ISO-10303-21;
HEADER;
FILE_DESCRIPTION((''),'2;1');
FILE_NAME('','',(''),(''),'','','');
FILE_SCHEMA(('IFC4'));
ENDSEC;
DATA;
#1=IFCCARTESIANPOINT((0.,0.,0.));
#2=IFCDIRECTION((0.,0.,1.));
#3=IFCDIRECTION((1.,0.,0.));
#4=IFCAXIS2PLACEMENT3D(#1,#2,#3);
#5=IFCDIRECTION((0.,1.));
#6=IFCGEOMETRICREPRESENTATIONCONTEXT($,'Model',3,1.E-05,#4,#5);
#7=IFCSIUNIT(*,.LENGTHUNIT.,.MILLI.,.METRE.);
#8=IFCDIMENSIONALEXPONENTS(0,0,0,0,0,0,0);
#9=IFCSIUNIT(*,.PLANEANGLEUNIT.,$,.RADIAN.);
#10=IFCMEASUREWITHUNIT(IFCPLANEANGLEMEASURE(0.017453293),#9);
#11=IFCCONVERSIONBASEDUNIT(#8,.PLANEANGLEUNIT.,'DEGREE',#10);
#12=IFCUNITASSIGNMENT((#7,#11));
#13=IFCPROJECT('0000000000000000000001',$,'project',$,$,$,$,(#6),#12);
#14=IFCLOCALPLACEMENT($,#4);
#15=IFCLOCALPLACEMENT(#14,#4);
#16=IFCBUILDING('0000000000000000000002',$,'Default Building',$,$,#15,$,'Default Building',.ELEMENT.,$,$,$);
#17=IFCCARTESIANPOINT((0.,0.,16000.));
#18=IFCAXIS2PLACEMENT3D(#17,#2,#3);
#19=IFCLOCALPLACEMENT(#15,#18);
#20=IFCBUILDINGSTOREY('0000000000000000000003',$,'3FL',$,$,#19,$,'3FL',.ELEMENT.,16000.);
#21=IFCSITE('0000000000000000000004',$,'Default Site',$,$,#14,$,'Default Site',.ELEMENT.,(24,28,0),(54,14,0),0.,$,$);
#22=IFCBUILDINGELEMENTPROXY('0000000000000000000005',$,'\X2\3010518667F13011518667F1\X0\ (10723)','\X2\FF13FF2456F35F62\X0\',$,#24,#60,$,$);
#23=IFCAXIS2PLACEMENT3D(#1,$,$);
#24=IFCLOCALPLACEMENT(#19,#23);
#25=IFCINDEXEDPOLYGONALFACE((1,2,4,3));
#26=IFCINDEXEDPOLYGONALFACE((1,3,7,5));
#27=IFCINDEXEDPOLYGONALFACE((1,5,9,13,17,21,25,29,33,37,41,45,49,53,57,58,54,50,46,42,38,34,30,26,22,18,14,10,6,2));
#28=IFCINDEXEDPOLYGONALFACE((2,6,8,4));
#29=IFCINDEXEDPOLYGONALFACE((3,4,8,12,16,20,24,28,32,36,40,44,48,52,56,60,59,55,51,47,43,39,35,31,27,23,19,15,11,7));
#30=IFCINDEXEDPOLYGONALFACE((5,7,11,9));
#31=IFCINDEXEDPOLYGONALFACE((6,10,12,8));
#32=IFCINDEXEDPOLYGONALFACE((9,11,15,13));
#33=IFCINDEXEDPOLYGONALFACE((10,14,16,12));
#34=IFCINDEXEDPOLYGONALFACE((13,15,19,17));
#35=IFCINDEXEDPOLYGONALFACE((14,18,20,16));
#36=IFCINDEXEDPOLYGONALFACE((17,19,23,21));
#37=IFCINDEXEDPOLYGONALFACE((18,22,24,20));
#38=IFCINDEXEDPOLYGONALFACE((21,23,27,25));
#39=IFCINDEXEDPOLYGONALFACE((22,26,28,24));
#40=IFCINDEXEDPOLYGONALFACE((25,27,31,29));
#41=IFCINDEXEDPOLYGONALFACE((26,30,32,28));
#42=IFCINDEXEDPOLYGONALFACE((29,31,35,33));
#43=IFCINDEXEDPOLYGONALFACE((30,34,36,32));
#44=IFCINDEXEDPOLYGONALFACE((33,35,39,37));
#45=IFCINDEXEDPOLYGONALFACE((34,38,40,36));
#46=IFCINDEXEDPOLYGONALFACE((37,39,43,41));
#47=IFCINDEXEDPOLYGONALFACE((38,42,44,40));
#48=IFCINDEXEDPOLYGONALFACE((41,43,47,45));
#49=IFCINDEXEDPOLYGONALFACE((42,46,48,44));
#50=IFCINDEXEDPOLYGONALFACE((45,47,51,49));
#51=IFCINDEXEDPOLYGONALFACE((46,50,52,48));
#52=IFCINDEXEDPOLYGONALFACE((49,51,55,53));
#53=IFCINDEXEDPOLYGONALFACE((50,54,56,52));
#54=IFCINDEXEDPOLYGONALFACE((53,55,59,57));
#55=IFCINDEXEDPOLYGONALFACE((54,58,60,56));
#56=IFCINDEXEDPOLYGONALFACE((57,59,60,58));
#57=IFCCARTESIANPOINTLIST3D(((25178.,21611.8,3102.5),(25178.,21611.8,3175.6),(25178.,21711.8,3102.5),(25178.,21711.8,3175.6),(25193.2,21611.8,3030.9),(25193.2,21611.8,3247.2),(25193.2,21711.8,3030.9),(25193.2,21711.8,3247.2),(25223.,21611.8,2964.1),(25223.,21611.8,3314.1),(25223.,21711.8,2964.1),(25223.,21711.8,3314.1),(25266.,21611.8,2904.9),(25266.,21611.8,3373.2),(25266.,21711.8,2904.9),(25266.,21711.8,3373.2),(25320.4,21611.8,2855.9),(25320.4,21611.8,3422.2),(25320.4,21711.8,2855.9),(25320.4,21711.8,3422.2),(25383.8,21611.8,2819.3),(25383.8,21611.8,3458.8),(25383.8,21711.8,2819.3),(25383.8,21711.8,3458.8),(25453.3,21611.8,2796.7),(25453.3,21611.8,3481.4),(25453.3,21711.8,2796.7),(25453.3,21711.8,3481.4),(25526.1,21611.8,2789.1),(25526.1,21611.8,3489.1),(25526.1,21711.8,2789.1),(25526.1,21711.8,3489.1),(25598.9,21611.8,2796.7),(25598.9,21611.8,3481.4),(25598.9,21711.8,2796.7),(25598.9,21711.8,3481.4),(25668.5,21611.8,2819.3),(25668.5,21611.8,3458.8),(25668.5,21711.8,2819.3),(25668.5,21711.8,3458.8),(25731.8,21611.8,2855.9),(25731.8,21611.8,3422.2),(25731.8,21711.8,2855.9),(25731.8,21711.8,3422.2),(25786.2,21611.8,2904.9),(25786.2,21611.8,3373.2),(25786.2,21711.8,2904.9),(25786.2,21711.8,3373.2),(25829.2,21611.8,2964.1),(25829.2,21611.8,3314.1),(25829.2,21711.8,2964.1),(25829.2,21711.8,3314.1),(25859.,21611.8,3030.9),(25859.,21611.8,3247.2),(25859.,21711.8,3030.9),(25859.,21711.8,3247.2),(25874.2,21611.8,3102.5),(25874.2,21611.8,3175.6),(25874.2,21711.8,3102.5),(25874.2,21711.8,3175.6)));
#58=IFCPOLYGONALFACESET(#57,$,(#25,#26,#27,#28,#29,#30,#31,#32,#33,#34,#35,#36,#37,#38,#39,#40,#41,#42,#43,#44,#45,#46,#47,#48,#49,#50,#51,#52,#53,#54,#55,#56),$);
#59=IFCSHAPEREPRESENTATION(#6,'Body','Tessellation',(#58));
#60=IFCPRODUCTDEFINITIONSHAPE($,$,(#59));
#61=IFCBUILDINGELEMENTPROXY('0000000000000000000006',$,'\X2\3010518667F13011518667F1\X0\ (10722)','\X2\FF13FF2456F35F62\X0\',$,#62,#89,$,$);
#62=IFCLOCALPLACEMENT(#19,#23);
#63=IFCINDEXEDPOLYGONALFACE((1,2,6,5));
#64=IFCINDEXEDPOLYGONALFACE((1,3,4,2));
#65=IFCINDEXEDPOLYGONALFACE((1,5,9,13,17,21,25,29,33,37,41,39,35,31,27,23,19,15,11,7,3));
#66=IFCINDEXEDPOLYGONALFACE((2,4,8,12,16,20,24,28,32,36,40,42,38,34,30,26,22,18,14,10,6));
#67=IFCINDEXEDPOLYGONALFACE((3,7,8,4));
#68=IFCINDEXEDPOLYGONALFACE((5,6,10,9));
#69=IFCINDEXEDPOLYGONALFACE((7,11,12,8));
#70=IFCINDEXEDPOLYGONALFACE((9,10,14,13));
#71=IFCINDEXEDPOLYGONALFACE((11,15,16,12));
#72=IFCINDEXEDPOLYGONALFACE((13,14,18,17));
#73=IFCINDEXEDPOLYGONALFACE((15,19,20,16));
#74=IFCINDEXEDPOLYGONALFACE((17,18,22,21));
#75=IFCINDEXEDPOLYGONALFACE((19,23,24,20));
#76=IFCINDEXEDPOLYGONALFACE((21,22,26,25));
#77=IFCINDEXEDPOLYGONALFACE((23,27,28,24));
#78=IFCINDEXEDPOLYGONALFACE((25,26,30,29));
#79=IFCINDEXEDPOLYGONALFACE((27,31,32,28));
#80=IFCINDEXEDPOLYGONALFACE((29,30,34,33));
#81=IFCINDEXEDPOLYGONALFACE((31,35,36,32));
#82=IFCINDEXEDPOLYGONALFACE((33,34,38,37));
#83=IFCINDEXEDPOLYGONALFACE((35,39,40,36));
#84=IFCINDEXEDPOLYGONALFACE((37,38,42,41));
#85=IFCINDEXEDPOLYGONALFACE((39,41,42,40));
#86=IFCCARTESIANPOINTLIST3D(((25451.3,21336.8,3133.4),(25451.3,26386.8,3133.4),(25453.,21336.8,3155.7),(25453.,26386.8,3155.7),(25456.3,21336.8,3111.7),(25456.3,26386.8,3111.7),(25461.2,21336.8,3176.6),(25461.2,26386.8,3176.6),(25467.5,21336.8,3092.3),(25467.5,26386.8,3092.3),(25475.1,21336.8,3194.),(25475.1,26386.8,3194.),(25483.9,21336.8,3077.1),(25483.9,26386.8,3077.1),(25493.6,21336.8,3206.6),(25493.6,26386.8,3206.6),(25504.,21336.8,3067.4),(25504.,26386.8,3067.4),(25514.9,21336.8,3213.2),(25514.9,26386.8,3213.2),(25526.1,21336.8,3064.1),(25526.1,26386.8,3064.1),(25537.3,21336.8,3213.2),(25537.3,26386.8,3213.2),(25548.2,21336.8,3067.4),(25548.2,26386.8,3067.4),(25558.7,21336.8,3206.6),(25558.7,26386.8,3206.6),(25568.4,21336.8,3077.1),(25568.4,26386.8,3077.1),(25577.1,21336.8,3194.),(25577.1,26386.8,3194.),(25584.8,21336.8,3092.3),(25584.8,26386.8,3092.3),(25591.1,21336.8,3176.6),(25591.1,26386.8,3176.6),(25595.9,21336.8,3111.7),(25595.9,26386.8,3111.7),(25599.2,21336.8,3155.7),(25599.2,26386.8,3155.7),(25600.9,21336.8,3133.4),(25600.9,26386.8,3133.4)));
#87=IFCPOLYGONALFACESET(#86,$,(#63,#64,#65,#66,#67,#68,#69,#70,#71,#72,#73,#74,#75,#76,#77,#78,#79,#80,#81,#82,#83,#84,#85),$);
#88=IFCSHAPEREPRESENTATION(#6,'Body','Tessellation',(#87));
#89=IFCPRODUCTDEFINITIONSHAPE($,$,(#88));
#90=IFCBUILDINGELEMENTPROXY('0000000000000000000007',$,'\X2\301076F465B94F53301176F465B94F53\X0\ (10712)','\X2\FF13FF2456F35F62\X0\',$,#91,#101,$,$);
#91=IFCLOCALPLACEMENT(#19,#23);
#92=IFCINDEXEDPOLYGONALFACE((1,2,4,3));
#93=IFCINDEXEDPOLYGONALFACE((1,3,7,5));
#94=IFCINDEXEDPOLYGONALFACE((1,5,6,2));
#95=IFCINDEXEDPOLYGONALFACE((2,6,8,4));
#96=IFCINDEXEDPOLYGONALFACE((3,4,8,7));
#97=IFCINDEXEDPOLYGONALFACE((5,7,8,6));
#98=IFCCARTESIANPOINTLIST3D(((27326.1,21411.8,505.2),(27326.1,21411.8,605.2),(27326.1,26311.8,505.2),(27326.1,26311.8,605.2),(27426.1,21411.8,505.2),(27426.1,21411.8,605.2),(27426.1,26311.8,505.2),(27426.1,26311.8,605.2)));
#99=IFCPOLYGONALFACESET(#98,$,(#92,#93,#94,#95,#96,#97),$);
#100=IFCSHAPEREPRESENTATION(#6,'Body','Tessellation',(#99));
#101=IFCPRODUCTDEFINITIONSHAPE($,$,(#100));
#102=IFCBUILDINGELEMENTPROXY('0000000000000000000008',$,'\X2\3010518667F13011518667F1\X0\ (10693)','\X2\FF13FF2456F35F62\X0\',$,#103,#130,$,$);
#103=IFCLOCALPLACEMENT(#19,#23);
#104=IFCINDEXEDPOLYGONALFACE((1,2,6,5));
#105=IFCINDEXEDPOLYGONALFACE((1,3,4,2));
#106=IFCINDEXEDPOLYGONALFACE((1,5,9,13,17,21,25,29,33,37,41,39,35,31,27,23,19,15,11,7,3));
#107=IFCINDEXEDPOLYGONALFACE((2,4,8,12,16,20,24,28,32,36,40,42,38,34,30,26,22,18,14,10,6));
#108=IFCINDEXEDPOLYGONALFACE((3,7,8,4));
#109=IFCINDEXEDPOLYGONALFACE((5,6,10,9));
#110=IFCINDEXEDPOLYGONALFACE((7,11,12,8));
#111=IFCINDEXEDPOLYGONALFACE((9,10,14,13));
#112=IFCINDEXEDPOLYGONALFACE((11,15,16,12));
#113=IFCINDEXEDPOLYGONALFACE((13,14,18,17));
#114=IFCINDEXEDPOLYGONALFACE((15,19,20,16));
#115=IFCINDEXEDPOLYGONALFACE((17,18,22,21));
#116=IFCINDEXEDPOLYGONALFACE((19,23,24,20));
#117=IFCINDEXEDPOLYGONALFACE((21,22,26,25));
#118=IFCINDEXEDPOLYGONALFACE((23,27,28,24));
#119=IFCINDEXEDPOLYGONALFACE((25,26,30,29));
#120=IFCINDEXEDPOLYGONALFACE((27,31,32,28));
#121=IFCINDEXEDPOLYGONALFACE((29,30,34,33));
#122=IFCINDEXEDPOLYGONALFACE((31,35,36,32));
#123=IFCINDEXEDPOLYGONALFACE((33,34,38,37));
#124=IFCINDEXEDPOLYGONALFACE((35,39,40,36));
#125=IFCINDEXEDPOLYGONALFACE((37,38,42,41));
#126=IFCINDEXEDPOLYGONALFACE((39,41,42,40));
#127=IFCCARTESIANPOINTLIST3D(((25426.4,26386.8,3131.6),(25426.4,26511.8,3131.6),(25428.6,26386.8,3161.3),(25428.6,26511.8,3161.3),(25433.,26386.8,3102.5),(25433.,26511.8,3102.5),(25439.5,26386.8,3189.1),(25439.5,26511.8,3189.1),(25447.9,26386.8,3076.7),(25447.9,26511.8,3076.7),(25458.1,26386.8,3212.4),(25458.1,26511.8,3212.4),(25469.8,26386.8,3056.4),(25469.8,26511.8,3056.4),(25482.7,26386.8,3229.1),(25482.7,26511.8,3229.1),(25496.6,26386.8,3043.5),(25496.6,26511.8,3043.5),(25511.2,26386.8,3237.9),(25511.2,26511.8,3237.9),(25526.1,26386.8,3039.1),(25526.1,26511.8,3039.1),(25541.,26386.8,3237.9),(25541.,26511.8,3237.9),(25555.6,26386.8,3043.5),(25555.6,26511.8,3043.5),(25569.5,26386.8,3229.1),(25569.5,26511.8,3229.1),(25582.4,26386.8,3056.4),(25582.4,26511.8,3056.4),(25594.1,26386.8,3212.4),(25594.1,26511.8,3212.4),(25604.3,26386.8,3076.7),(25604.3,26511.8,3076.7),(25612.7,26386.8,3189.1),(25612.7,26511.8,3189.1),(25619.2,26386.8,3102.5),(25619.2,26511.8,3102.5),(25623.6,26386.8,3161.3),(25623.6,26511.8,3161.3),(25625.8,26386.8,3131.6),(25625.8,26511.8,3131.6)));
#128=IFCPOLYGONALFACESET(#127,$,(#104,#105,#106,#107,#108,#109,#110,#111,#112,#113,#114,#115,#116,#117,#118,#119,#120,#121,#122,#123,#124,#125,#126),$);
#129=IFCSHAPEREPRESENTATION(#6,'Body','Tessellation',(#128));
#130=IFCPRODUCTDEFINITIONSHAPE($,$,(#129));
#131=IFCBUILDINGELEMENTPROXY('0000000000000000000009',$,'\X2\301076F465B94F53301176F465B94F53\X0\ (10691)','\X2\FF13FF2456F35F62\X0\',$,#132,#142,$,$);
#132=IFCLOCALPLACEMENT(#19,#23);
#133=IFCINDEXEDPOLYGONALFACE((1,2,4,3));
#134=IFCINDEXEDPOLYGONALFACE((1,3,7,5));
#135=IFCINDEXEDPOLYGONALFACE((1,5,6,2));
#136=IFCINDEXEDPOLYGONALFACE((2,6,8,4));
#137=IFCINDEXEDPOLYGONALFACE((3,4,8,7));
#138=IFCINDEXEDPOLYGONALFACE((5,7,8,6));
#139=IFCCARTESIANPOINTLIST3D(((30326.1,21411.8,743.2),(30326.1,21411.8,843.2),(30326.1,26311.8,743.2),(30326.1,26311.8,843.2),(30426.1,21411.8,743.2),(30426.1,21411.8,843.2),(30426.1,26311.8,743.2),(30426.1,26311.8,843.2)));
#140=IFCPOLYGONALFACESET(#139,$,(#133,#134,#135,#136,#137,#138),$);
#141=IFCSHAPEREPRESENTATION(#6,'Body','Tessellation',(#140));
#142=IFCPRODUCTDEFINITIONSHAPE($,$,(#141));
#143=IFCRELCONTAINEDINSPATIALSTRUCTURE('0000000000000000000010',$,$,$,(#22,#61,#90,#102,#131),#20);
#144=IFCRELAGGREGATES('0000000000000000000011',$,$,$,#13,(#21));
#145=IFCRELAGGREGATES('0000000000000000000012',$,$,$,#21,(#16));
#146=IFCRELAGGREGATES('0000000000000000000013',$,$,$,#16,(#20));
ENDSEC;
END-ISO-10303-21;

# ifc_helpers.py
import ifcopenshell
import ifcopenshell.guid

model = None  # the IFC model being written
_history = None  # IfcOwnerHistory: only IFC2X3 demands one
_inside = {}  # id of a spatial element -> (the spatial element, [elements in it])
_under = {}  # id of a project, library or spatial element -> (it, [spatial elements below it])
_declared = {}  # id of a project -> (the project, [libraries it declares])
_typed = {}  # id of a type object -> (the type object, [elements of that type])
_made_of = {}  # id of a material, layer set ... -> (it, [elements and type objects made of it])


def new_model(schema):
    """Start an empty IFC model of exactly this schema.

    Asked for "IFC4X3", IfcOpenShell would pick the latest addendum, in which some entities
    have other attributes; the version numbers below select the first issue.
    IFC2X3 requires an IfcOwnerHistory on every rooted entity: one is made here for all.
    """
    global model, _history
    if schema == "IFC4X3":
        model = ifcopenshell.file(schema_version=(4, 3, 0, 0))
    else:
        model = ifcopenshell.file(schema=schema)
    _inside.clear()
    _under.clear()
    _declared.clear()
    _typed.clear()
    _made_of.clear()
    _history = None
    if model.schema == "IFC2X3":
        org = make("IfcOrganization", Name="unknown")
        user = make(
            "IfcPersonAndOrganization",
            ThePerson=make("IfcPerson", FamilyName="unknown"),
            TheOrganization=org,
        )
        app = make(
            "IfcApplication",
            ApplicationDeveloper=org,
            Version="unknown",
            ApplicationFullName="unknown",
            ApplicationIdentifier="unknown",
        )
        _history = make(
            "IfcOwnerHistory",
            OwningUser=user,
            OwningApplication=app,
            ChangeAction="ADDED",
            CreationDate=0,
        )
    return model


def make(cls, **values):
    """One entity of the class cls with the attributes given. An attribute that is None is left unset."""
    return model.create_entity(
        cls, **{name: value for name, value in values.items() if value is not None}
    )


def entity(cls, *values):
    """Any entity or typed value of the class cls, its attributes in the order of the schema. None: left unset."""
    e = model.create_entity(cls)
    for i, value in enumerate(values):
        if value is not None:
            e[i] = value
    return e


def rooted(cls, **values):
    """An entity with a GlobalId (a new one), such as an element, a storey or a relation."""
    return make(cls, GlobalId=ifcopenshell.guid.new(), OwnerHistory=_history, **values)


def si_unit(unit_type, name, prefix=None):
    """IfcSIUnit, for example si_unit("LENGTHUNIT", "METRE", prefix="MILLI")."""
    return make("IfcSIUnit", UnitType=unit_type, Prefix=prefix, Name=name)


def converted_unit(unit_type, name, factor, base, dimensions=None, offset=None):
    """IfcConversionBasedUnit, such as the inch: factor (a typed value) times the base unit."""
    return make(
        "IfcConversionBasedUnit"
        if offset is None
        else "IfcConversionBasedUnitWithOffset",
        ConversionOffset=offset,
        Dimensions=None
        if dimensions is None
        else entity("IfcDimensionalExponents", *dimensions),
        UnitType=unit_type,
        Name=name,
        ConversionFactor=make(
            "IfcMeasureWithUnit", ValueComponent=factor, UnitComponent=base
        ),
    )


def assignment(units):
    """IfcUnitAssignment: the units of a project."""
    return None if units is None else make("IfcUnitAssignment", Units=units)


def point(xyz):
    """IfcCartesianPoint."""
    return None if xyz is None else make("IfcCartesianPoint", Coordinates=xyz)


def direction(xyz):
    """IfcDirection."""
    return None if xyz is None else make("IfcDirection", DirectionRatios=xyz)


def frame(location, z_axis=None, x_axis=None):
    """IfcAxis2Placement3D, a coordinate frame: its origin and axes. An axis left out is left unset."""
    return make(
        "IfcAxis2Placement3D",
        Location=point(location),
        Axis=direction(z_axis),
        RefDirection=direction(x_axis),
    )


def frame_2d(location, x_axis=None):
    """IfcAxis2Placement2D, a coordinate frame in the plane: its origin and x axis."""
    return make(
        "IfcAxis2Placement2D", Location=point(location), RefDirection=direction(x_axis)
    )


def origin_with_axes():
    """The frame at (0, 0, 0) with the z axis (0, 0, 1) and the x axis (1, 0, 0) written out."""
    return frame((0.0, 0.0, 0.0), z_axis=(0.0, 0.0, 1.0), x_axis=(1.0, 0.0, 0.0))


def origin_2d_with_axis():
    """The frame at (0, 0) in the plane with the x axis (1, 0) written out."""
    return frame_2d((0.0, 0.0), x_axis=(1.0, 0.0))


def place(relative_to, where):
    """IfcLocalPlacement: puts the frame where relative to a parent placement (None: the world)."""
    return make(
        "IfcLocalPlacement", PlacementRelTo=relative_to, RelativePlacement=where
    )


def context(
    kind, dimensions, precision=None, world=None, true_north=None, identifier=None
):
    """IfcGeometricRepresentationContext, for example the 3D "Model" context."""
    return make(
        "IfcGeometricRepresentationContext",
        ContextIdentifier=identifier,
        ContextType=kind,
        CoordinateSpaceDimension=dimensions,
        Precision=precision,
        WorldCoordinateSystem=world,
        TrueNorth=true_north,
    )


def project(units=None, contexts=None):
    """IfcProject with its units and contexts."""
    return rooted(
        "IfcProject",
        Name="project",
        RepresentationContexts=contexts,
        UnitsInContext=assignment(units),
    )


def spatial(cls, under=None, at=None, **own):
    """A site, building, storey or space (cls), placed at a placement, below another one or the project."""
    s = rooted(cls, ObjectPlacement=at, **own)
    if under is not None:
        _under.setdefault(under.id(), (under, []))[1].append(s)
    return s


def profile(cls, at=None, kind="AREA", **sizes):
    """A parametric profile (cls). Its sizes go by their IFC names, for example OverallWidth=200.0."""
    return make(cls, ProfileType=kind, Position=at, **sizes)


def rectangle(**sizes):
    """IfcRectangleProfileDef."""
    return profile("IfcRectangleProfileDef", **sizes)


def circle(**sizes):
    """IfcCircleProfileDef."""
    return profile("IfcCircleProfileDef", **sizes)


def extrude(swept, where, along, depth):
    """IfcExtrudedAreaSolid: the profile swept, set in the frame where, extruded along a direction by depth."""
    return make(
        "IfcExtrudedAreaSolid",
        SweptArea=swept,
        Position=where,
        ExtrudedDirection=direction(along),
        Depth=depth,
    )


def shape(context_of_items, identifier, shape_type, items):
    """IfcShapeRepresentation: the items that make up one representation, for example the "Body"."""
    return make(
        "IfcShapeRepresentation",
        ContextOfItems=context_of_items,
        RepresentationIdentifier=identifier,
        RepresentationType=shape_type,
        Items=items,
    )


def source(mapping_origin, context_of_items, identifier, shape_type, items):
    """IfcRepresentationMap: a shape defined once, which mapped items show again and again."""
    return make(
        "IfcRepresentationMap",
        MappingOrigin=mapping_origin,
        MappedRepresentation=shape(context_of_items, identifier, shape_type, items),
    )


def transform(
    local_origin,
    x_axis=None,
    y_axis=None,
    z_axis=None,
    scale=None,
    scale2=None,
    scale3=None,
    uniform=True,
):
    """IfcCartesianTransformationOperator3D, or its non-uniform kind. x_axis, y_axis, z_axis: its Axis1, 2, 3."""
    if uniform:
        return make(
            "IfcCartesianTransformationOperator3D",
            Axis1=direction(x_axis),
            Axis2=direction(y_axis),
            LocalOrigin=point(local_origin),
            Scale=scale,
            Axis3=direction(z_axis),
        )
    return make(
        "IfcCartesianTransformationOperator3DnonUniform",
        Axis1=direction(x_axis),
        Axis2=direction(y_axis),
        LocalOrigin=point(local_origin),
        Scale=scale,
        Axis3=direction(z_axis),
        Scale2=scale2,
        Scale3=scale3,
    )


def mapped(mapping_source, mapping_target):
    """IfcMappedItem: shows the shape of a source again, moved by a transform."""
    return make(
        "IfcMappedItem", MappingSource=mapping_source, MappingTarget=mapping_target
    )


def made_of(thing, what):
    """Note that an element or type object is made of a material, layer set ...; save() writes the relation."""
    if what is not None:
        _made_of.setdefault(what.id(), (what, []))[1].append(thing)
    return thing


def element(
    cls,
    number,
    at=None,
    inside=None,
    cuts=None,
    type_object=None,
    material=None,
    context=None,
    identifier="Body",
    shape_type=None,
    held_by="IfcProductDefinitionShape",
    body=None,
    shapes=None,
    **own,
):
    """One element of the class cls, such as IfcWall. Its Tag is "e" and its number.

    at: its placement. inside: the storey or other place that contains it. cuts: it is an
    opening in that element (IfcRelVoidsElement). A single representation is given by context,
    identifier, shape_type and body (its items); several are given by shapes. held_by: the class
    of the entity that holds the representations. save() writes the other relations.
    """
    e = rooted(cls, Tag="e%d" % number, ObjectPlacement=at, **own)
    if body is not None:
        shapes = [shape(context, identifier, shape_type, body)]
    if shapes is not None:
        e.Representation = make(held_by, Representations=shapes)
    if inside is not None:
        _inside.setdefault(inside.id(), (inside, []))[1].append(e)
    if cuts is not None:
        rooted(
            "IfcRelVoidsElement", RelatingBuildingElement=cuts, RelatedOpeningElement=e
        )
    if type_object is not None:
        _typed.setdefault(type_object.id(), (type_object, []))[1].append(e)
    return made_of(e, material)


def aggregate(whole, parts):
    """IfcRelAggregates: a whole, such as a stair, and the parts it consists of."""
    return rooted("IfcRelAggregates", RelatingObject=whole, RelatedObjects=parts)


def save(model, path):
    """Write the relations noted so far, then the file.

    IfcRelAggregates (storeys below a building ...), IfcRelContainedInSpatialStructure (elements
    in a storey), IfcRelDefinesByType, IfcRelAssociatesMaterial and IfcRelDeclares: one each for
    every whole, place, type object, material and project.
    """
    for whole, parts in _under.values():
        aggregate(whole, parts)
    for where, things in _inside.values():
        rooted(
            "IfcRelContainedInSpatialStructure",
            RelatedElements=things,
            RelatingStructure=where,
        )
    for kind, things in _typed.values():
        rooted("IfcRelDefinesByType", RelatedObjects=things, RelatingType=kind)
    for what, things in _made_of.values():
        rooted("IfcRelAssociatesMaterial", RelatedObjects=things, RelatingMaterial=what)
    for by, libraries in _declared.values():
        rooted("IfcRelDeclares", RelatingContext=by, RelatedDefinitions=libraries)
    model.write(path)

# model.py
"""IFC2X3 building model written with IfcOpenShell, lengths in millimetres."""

from ifc_helpers import new_model, entity, si_unit, converted_unit, direction, frame, origin_with_axes, origin_2d_with_axis, place, context, project, spatial, rectangle, circle, extrude, source, transform, mapped, element, save


model = new_model("IFC2X3")

# Units and contexts
model_context = context("Model", 3, precision=1e-05, world=origin_with_axes(), true_north=direction((0.0, 1.0)))
ifc_project = project(units=[si_unit("LENGTHUNIT", "METRE", prefix="MILLI"), converted_unit("PLANEANGLEUNIT", "DEGREE", entity("IfcPlaneAngleMeasure", 0.017453293), si_unit("PLANEANGLEUNIT", "RADIAN"), dimensions=[0, 0, 0, 0, 0, 0, 0])], contexts=[model_context])

# Site, building, storey
site_placement = place(None, origin_with_axes())
site = spatial("IfcSite", under=ifc_project, at=site_placement, Name="Default Site", LongName="Default Site", CompositionType="ELEMENT", RefLatitude=(24, 28, 0), RefLongitude=(54, 14, 0), RefElevation=0.0)
building_placement = place(site_placement, origin_with_axes())
building = spatial("IfcBuilding", under=site, at=building_placement, Name="Default Building", LongName="Default Building", CompositionType="ELEMENT")
storey_placement = place(building_placement, frame((0.0, 0.0, 16000.0), z_axis=(0.0, 0.0, 1.0), x_axis=(1.0, 0.0, 0.0)))
storey = spatial("IfcBuildingStorey", under=building, at=storey_placement, Name="3FL", LongName="3FL", CompositionType="ELEMENT", Elevation=16000.0)

# Building element proxies
shared_shape_1 = source(origin_with_axes(), model_context, "Body", "SweptSolid", [
    extrude(circle(Radius=350.0, at=origin_2d_with_axis()), frame((0.0, 0.0, 0.0), z_axis=(0.0, 0.0, 1.0), x_axis=(1.0, 0.0, 0.0)), (0.0, 0.0, 1.0), 100.0),
])
proxy_1_placement = place(storey_placement, frame((25526.1, 21611.8, 3139.1), z_axis=(0.0, 1.0, 0.0), x_axis=(0.0, 0.0, -1.0)))
element("IfcBuildingElementProxy", 1, at=proxy_1_placement, inside=storey, Name="【円柱】円柱 (10723)", Description="３Ｄ図形", context=model_context, shape_type="MappedRepresentation", body=[
    mapped(shared_shape_1, transform((0.0, 0.0, 0.0))),
])
shared_shape_2 = source(origin_with_axes(), model_context, "Body", "SweptSolid", [
    extrude(circle(Radius=75.0, at=origin_2d_with_axis()), frame((0.0, 0.0, 0.0), z_axis=(0.0, 0.0, 1.0), x_axis=(1.0, 0.0, 0.0)), (0.0, 0.0, 1.0), 5050.0),
])
proxy_2_placement = place(storey_placement, frame((25526.1, 21336.8, 3139.1), z_axis=(0.0, 1.0, 0.0), x_axis=(0.0, 0.0, -1.0)))
element("IfcBuildingElementProxy", 2, at=proxy_2_placement, inside=storey, Name="【円柱】円柱 (10722)", Description="３Ｄ図形", context=model_context, shape_type="MappedRepresentation", body=[
    mapped(shared_shape_2, transform((0.0, 0.0, 0.0))),
])
shared_shape_3 = source(origin_with_axes(), model_context, "Body", "SweptSolid", [
    extrude(rectangle(XDim=100.0, YDim=4900.0, at=origin_2d_with_axis()), origin_with_axes(), (0.0, 0.0, 1.0), 100.0),
])
proxy_3_placement = place(storey_placement, frame((27376.1, 23861.8, 505.2), z_axis=(0.0, 0.0, 1.0), x_axis=(1.0, 0.0, 0.0)))
element("IfcBuildingElementProxy", 3, at=proxy_3_placement, inside=storey, Name="【直方体】直方体 (10712)", Description="３Ｄ図形", context=model_context, shape_type="MappedRepresentation", body=[
    mapped(shared_shape_3, transform((0.0, 0.0, 0.0))),
])
shared_shape_4 = source(origin_with_axes(), model_context, "Body", "SweptSolid", [
    extrude(circle(Radius=100.0, at=origin_2d_with_axis()), frame((0.0, 0.0, 0.0), z_axis=(0.0, 0.0, 1.0), x_axis=(1.0, 0.0, 0.0)), (0.0, 0.0, 1.0), 125.0),
])
proxy_4_placement = place(storey_placement, frame((25526.1, 26386.8, 3139.1), z_axis=(0.0, 1.0, 0.0), x_axis=(0.0, 0.0, -1.0)))
element("IfcBuildingElementProxy", 4, at=proxy_4_placement, inside=storey, Name="【円柱】円柱 (10693)", Description="３Ｄ図形", context=model_context, shape_type="MappedRepresentation", body=[
    mapped(shared_shape_4, transform((0.0, 0.0, 0.0))),
])
shared_shape_5 = source(origin_with_axes(), model_context, "Body", "SweptSolid", [
    extrude(rectangle(XDim=100.0, YDim=4900.0, at=origin_2d_with_axis()), origin_with_axes(), (0.0, 0.0, 1.0), 100.0),
])
proxy_5_placement = place(storey_placement, frame((30376.1, 23861.8, 743.2), z_axis=(0.0, 0.0, 1.0), x_axis=(1.0, 0.0, 0.0)))
element("IfcBuildingElementProxy", 5, at=proxy_5_placement, inside=storey, Name="【直方体】直方体 (10691)", Description="３Ｄ図形", context=model_context, shape_type="MappedRepresentation", body=[
    mapped(shared_shape_5, transform((0.0, 0.0, 0.0))),
])

save(model, "model.ifc")
